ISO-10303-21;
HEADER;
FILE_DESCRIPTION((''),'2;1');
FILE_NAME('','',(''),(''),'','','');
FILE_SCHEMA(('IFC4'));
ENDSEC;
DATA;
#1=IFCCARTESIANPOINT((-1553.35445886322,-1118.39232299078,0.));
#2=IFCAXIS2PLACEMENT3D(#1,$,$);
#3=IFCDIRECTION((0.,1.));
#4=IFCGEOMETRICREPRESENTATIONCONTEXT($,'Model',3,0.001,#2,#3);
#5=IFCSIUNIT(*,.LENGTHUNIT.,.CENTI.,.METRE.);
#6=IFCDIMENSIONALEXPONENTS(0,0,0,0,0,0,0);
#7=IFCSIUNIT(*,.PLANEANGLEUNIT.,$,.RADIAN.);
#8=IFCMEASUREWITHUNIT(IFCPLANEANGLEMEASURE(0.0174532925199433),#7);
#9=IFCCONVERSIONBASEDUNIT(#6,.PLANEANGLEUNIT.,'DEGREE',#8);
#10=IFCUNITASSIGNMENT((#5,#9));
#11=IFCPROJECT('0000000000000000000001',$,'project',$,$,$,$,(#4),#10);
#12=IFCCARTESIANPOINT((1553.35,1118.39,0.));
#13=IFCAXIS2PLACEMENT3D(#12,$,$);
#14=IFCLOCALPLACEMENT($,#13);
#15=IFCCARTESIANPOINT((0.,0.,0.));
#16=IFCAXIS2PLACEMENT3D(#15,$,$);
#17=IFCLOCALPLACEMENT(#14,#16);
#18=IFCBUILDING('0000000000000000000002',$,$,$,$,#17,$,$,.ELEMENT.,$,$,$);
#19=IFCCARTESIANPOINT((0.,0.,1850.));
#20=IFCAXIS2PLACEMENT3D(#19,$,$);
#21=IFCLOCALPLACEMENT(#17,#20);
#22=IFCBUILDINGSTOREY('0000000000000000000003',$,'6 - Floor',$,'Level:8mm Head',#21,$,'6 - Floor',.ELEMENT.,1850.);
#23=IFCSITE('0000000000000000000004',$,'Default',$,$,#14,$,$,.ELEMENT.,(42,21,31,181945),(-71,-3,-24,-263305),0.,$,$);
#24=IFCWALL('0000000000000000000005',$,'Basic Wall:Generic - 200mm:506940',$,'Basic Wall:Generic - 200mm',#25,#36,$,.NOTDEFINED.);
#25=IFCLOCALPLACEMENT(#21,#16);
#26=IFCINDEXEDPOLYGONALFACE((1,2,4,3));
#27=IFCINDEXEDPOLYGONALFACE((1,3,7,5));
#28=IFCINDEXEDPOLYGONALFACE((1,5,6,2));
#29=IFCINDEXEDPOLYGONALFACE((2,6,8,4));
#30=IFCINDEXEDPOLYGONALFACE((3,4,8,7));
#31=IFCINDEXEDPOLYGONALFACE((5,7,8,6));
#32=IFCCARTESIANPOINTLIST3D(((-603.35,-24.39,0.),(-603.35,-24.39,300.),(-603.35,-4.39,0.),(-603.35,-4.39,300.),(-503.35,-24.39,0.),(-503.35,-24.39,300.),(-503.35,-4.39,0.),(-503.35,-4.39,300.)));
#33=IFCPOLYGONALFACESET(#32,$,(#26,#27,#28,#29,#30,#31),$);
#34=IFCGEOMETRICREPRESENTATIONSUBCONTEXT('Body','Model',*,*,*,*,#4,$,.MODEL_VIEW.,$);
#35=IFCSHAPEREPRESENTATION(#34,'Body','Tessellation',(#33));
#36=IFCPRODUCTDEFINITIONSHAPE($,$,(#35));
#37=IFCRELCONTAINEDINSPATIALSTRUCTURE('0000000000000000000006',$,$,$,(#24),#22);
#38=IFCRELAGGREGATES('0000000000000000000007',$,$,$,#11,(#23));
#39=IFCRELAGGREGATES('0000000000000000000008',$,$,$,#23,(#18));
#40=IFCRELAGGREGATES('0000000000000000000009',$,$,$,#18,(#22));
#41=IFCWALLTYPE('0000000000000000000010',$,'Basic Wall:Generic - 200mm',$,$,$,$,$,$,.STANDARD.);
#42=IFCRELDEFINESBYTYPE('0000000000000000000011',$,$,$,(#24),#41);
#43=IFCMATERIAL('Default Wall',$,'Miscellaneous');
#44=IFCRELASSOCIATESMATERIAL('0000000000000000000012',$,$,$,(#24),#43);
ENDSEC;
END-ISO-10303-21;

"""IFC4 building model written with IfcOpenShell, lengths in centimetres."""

from ifc_helpers import new_model, entity, si_unit, converted_unit, direction, frame, origin, place, context, subcontext, project, spatial, indexed_curve, outline, extrude, material, type_object, element, save


model = new_model("IFC4")

# Units and contexts
model_context = context("Model", 3, precision=0.001, world=frame((-1553.35445886322, -1118.39232299078, 0.0)), true_north=direction((0.0, 1.0)))
body_context = subcontext(model_context, "Body", "Model", "MODEL_VIEW")
ifc_project = project(units=[si_unit("LENGTHUNIT", "METRE", prefix="CENTI"), converted_unit("PLANEANGLEUNIT", "DEGREE", entity("IfcPlaneAngleMeasure", 0.0174532925199433), si_unit("PLANEANGLEUNIT", "RADIAN"), dimensions=[0, 0, 0, 0, 0, 0, 0])], contexts=[model_context])

# Site, building, storey
site_placement = place(None, frame((1553.35, 1118.39, 0.0)))
site = spatial("IfcSite", under=ifc_project, at=site_placement, Name="Default", CompositionType="ELEMENT", RefLatitude=(42, 21, 31, 181945), RefLongitude=(-71, -3, -24, -263305), RefElevation=0.0)
building_placement = place(site_placement, origin())
building = spatial("IfcBuilding", under=site, at=building_placement, CompositionType="ELEMENT")
storey_placement = place(building_placement, frame((0.0, 0.0, 1850.0)))
storey = spatial("IfcBuildingStorey", under=building, at=storey_placement, Name="6 - Floor", ObjectType="Level:8mm Head", LongName="6 - Floor", CompositionType="ELEMENT", Elevation=1850.0)

# Wall
ifc_material_1 = material(Name="Default Wall", Category="Miscellaneous")
wall_type_1 = type_object("IfcWallType", Name="Basic Wall:Generic - 200mm", PredefinedType="STANDARD")
wall_1_placement = place(storey_placement, frame((-603.35, -14.39, 0.0)))
element("IfcWall", 1, at=wall_1_placement, inside=storey, type_object=wall_type_1, material=ifc_material_1, Name="Basic Wall:Generic - 200mm:506940", ObjectType="Basic Wall:Generic - 200mm", PredefinedType="NOTDEFINED", context=body_context, shape_type="SweptSolid", body=[
    extrude(outline(indexed_curve([(100.0, 10.0), (0.0, 10.0), (0.0, -10.0), (100.0, -10.0), (100.0, 10.0)], self_intersect=False)), origin(), (0.0, 0.0, 1.0), 300.0),
])

save(model, "model.ifc")
